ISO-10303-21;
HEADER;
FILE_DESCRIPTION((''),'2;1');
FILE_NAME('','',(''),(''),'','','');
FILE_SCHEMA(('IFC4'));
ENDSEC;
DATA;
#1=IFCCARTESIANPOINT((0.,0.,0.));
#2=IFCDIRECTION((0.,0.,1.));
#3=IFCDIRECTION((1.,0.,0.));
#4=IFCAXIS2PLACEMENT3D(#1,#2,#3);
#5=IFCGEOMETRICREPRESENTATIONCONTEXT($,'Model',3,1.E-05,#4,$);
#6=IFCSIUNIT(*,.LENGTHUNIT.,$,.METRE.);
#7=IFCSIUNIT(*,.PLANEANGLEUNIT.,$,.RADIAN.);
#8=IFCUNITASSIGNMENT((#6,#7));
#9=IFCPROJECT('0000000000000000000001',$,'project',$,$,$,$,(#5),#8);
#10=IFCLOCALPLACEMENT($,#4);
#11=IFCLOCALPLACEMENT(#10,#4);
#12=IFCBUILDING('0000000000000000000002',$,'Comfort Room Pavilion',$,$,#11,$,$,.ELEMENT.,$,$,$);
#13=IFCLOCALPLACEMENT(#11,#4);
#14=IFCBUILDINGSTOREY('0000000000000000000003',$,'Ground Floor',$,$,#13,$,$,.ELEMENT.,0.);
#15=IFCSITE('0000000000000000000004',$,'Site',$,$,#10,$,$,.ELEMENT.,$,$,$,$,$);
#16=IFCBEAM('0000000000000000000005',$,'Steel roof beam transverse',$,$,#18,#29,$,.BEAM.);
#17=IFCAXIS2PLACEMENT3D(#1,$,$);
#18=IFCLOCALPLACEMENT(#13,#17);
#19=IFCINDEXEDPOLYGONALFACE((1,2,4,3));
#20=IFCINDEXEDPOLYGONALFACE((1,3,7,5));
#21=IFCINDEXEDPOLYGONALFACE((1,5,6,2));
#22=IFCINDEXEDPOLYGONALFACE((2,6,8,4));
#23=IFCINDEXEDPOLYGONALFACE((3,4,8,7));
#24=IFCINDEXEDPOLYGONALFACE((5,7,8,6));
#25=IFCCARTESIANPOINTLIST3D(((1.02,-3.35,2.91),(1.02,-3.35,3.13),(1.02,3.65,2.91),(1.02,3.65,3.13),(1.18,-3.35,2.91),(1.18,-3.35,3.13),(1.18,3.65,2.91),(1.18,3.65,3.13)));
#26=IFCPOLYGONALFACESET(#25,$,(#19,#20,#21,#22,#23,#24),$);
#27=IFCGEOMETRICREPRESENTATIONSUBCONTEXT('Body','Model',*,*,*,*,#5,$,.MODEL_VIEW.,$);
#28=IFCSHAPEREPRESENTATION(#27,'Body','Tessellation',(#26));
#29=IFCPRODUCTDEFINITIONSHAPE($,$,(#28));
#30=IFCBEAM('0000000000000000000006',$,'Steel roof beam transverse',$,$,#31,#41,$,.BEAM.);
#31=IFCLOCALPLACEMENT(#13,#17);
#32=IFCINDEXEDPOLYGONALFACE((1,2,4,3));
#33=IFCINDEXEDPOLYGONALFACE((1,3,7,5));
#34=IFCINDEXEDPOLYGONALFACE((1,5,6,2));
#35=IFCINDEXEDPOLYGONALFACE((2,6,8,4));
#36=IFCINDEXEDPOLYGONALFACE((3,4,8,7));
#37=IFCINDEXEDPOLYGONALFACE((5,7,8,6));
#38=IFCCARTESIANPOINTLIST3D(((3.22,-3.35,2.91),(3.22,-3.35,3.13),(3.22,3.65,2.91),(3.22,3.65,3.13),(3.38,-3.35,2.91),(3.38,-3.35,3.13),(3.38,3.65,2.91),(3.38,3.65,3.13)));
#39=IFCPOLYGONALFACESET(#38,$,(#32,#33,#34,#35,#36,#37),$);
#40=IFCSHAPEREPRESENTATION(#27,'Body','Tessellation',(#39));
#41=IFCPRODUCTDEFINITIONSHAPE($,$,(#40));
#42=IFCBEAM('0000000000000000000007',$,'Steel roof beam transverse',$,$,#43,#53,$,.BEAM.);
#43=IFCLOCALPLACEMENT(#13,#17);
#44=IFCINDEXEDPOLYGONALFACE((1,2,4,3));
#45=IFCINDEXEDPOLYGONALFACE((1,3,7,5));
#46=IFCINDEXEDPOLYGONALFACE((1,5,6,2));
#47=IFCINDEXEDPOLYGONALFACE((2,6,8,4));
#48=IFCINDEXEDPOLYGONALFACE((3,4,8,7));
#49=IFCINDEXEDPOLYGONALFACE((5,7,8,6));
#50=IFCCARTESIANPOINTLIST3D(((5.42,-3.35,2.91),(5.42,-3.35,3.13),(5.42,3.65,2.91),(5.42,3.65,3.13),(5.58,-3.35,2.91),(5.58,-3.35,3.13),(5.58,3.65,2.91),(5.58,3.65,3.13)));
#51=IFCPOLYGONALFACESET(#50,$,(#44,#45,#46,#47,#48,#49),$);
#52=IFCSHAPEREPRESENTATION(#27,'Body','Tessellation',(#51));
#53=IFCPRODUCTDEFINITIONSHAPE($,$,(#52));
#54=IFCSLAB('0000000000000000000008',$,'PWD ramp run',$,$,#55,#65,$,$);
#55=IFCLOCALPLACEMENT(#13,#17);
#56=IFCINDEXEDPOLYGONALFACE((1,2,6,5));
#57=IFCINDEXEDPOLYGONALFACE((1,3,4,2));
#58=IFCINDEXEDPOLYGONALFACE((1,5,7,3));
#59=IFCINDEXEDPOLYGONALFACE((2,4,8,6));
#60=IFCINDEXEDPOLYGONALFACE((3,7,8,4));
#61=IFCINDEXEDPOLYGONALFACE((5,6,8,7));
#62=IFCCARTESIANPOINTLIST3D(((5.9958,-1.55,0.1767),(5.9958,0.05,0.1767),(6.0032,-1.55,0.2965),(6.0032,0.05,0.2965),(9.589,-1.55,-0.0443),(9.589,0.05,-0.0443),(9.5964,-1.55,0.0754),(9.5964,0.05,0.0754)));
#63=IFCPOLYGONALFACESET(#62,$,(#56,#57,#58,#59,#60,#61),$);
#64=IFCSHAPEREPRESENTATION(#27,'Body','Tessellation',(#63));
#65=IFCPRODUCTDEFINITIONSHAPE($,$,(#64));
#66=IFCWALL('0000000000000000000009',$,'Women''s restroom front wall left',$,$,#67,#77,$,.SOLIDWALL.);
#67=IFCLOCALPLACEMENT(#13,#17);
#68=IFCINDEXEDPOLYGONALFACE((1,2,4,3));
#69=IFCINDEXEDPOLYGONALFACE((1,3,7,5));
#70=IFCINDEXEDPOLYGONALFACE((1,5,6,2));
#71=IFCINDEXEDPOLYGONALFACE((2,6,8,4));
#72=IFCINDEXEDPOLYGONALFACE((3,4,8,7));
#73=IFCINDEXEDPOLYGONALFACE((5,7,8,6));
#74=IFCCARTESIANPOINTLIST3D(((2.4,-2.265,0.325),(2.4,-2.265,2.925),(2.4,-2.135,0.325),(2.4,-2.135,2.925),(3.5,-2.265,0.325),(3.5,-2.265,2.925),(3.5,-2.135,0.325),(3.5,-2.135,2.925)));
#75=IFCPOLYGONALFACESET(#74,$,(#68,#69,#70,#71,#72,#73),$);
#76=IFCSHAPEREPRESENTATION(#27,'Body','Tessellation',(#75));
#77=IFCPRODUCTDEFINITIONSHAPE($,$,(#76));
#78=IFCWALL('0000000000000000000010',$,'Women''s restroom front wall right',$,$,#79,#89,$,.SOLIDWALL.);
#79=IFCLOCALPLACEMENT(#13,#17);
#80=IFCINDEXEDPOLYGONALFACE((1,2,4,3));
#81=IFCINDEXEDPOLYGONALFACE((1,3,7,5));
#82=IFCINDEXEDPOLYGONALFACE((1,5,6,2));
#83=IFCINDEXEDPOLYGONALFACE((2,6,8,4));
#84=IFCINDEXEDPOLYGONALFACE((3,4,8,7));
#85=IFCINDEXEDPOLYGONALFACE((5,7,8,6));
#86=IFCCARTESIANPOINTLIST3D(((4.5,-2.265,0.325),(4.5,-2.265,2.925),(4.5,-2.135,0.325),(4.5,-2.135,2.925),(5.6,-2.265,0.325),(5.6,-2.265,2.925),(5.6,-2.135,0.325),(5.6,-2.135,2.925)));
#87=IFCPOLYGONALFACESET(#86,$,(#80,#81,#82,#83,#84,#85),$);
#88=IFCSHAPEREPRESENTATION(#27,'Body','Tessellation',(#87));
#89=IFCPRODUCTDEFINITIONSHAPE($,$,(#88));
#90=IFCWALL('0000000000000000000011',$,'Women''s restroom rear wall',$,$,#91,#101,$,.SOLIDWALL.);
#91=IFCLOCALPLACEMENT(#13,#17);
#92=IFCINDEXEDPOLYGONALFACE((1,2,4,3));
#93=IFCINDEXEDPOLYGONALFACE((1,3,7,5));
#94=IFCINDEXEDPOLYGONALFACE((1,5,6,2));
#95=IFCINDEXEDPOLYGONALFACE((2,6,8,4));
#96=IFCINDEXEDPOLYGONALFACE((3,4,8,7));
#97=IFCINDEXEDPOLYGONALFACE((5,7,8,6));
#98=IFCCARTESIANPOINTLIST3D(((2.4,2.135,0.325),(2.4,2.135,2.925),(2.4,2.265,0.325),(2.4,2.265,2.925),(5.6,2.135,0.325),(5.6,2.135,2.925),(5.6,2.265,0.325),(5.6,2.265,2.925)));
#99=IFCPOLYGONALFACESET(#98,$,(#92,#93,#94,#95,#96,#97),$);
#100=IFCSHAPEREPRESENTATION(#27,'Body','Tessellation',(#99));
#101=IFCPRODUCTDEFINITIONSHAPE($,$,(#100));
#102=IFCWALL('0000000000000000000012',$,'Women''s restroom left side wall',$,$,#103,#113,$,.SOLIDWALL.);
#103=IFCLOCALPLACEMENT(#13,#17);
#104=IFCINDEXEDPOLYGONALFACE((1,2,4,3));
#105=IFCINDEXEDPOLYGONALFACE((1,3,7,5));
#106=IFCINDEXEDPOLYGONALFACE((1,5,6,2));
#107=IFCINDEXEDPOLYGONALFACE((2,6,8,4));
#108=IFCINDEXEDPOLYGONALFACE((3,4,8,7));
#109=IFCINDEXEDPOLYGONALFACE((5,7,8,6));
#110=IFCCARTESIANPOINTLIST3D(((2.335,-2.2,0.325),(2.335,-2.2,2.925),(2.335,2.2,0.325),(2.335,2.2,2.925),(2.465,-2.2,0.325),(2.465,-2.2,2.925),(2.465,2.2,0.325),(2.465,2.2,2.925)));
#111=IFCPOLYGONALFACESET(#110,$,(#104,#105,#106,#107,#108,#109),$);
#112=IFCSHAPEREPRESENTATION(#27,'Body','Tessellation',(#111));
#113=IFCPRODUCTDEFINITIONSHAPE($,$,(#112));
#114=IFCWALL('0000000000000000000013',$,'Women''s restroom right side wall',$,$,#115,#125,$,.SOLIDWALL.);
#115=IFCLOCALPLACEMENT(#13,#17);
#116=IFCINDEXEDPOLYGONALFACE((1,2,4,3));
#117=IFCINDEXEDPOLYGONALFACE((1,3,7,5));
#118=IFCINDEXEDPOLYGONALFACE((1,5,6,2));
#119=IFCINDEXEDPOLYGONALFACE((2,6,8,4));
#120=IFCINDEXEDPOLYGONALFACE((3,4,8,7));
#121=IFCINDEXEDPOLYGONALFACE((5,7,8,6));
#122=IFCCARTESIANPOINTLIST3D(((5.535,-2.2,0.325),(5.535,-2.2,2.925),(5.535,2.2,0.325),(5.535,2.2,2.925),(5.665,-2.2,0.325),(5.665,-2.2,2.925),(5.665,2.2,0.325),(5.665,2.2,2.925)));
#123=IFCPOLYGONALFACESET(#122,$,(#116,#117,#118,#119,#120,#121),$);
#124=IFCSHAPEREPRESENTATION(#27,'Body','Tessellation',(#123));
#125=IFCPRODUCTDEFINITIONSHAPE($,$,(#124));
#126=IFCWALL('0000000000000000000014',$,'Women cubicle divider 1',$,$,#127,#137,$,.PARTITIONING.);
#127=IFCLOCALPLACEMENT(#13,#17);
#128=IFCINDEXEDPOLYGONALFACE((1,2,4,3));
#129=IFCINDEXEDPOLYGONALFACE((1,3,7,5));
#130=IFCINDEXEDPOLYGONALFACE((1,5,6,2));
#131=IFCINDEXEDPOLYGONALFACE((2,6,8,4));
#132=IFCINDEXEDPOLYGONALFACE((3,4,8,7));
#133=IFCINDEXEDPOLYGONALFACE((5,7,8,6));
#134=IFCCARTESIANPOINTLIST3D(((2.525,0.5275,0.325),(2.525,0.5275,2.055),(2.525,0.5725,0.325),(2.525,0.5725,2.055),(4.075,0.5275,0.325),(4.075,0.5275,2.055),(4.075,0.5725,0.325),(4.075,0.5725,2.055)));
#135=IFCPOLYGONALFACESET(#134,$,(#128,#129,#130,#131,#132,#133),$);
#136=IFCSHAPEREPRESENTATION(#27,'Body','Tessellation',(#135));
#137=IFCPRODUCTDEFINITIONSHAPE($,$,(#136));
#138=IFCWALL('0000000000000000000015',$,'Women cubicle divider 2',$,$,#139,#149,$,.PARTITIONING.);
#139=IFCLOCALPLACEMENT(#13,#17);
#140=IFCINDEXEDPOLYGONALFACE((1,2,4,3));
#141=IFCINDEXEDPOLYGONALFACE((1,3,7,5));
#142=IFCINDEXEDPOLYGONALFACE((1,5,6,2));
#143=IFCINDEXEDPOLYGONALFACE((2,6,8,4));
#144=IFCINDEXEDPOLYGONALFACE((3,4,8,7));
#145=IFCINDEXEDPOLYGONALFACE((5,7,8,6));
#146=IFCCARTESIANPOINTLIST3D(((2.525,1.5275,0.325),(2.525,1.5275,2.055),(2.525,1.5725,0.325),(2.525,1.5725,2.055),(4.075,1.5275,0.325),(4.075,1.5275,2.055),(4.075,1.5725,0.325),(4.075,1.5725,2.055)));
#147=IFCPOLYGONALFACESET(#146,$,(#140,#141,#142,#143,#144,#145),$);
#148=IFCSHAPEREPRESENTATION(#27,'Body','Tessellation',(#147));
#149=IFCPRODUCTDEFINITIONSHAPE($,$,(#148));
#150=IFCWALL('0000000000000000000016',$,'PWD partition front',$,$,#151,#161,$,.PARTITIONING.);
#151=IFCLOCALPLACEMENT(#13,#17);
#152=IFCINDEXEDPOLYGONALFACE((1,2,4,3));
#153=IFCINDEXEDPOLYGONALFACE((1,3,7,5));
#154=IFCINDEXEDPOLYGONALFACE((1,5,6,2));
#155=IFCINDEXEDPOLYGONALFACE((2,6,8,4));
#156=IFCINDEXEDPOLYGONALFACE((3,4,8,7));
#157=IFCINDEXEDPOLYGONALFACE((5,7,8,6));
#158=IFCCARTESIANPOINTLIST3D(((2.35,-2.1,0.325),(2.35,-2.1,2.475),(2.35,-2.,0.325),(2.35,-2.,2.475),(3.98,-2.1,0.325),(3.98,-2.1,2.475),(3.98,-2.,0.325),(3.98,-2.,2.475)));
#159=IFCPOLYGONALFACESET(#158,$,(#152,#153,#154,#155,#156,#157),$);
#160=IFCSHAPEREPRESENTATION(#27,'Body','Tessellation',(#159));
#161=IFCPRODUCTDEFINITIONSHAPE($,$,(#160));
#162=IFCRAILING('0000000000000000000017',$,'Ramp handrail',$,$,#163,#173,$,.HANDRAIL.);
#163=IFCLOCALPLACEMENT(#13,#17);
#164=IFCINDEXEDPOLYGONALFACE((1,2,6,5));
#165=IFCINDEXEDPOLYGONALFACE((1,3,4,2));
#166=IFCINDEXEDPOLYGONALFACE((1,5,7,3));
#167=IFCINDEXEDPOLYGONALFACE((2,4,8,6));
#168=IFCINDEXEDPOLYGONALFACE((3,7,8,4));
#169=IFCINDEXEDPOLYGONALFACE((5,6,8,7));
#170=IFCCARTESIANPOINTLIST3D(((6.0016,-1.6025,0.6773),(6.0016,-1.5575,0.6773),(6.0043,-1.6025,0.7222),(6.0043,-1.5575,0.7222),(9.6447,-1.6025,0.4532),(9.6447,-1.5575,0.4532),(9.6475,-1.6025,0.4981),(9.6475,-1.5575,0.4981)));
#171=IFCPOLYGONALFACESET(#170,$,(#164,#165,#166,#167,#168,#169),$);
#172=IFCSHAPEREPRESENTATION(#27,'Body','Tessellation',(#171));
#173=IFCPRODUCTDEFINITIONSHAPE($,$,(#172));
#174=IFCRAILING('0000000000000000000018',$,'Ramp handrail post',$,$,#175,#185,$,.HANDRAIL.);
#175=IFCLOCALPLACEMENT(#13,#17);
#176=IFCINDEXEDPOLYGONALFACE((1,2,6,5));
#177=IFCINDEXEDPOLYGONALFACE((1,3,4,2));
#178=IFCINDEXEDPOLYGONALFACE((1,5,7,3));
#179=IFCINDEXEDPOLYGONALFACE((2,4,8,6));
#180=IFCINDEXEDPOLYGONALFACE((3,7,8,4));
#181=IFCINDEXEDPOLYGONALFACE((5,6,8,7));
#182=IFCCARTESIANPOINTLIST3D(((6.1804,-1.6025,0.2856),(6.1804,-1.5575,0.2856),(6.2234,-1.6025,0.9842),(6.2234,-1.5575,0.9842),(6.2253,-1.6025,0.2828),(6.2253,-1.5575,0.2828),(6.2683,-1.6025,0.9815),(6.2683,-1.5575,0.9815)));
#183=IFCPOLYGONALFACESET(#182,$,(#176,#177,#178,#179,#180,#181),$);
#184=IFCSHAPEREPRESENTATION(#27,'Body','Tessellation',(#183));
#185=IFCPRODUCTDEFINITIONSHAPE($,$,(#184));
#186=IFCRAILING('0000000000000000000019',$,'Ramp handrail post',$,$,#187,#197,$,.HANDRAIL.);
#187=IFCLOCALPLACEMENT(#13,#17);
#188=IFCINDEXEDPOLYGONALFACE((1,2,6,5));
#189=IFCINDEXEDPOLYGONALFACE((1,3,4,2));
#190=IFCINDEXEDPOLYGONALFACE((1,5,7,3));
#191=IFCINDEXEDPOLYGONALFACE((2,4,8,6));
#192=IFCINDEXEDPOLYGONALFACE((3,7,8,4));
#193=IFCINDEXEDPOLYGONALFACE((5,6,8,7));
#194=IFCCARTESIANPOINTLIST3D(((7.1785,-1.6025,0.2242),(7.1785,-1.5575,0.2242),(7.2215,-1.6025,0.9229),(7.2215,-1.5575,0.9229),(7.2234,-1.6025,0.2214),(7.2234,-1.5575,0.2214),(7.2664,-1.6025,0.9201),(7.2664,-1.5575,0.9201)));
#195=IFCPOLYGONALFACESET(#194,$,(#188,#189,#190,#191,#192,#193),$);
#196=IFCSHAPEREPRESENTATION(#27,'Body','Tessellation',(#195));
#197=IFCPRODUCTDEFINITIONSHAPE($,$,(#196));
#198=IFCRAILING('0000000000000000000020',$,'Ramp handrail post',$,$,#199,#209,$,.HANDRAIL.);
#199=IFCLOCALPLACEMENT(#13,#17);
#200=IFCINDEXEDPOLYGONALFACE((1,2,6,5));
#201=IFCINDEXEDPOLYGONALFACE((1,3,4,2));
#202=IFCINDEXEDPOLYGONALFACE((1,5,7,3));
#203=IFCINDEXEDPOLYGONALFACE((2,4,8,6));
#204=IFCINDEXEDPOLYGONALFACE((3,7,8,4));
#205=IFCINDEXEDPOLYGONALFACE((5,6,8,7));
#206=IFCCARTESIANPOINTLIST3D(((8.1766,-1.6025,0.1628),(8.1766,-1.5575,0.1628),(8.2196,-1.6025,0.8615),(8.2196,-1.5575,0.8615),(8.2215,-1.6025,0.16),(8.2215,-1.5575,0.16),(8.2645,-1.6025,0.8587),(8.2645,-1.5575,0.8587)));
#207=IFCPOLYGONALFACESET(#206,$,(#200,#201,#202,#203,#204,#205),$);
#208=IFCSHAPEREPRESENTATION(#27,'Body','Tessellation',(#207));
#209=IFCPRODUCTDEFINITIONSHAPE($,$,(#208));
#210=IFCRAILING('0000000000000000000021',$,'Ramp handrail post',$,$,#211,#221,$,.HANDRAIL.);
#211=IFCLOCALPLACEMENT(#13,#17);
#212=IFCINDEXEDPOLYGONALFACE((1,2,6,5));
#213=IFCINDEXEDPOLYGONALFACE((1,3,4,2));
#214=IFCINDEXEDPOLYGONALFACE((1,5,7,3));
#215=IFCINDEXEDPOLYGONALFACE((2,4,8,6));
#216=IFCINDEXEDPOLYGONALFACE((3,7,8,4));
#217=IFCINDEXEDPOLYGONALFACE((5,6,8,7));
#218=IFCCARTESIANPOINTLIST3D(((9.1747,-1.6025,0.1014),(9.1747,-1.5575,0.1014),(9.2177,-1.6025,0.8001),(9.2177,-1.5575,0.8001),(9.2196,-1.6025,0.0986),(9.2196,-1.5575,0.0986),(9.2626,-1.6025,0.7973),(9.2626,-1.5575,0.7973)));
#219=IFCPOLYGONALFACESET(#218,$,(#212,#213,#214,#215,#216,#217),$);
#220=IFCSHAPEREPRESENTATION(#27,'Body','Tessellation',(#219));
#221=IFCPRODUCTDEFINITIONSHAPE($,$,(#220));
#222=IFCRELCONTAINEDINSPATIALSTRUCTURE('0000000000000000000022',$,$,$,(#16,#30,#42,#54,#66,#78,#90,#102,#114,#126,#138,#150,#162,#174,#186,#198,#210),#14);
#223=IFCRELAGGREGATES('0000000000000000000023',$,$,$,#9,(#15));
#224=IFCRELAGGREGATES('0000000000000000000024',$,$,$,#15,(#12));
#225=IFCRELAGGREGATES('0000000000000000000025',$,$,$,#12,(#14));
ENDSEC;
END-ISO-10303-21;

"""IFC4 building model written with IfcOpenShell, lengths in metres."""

from ifc_helpers import new_model, si_unit, frame, origin_with_axes, origin_2d, place, context, subcontext, project, spatial, rectangle, extrude, element, save


model = new_model("IFC4")

# Units and contexts
model_context = context("Model", 3, precision=1e-05, world=origin_with_axes())
body_context = subcontext(model_context, "Body", "Model", "MODEL_VIEW")
ifc_project = project(units=[si_unit("LENGTHUNIT", "METRE"), si_unit("PLANEANGLEUNIT", "RADIAN")], contexts=[model_context])

# Site, building, storey
site_placement = place(None, origin_with_axes())
site = spatial("IfcSite", under=ifc_project, at=site_placement, Name="Site", CompositionType="ELEMENT")
building_placement = place(site_placement, origin_with_axes())
building = spatial("IfcBuilding", under=site, at=building_placement, Name="Comfort Room Pavilion", CompositionType="ELEMENT")
storey_placement = place(building_placement, origin_with_axes())
storey = spatial("IfcBuildingStorey", under=building, at=storey_placement, Name="Ground Floor", CompositionType="ELEMENT", Elevation=0.0)

# Beams
for number, where, z_axis, x_axis, name in (
    (1, (1.1, 0.15, 2.91), (0.0, 0.0, 1.0), (1.0, 0.0, 0.0), "Steel roof beam transverse"),
    (2, (3.3, 0.15, 2.91), (0.0, 0.0, 1.0), (1.0, 0.0, 0.0), "Steel roof beam transverse"),
    (3, (5.5, 0.15, 2.91), (0.0, 0.0, 1.0), (1.0, 0.0, 0.0), "Steel roof beam transverse"),
):
    element("IfcBeam", number, at=place(storey_placement, frame(where, z_axis=z_axis, x_axis=x_axis)), inside=storey, Name=name, PredefinedType="BEAM", context=body_context, shape_type="SweptSolid", body=[
        extrude(rectangle(XDim=0.16, YDim=7.0, at=origin_2d()), origin_with_axes(), (0.0, 0.0, 1.0), 0.22),
    ])

# Slab
slab_placement = place(storey_placement, frame((7.7924, -0.75, 0.0662), z_axis=(0.061397, 0.0, 0.998113), x_axis=(0.998113, 0.0, -0.061397)))
element("IfcSlab", 4, at=slab_placement, inside=storey, Name="PWD ramp run", context=body_context, shape_type="SweptSolid", body=[
    extrude(rectangle(XDim=3.6, YDim=1.6, at=origin_2d()), origin_with_axes(), (0.0, 0.0, 1.0), 0.12),
])

# Walls
for number, where, z_axis, x_axis, name in (
    (5, (2.95, -2.2, 0.325), (0.0, 0.0, 1.0), (1.0, 0.0, 0.0), "Women's restroom front wall left"),
    (6, (5.05, -2.2, 0.325), (0.0, 0.0, 1.0), (1.0, 0.0, 0.0), "Women's restroom front wall right"),
):
    element("IfcWall", number, at=place(storey_placement, frame(where, z_axis=z_axis, x_axis=x_axis)), inside=storey, Name=name, PredefinedType="SOLIDWALL", context=body_context, shape_type="SweptSolid", body=[
        extrude(rectangle(XDim=1.1, YDim=0.13, at=origin_2d()), origin_with_axes(), (0.0, 0.0, 1.0), 2.6),
    ])
wall_1_placement = place(storey_placement, frame((4.0, 2.2, 0.325), z_axis=(0.0, 0.0, 1.0), x_axis=(1.0, 0.0, 0.0)))
element("IfcWall", 7, at=wall_1_placement, inside=storey, Name="Women's restroom rear wall", PredefinedType="SOLIDWALL", context=body_context, shape_type="SweptSolid", body=[
    extrude(rectangle(XDim=3.2, YDim=0.13, at=origin_2d()), origin_with_axes(), (0.0, 0.0, 1.0), 2.6),
])
for number, where, z_axis, x_axis, name in (
    (8, (2.4, 0.0, 0.325), (0.0, 0.0, 1.0), (1.0, 0.0, 0.0), "Women's restroom left side wall"),
    (9, (5.6, 0.0, 0.325), (0.0, 0.0, 1.0), (1.0, 0.0, 0.0), "Women's restroom right side wall"),
):
    element("IfcWall", number, at=place(storey_placement, frame(where, z_axis=z_axis, x_axis=x_axis)), inside=storey, Name=name, PredefinedType="SOLIDWALL", context=body_context, shape_type="SweptSolid", body=[
        extrude(rectangle(XDim=0.13, YDim=4.4, at=origin_2d()), origin_with_axes(), (0.0, 0.0, 1.0), 2.6),
    ])
for number, where, z_axis, x_axis, name in (
    (10, (3.3, 0.55, 0.325), (0.0, 0.0, 1.0), (1.0, 0.0, 0.0), "Women cubicle divider 1"),
    (11, (3.3, 1.55, 0.325), (0.0, 0.0, 1.0), (1.0, 0.0, 0.0), "Women cubicle divider 2"),
):
    element("IfcWall", number, at=place(storey_placement, frame(where, z_axis=z_axis, x_axis=x_axis)), inside=storey, Name=name, PredefinedType="PARTITIONING", context=body_context, shape_type="SweptSolid", body=[
        extrude(rectangle(XDim=1.55, YDim=0.045, at=origin_2d()), origin_with_axes(), (0.0, 0.0, 1.0), 1.73),
    ])
wall_2_placement = place(storey_placement, frame((3.165, -2.05, 0.325), z_axis=(0.0, 0.0, 1.0), x_axis=(1.0, 0.0, 0.0)))
element("IfcWall", 12, at=wall_2_placement, inside=storey, Name="PWD partition front", PredefinedType="PARTITIONING", context=body_context, shape_type="SweptSolid", body=[
    extrude(rectangle(XDim=1.63, YDim=0.1, at=origin_2d()), origin_with_axes(), (0.0, 0.0, 1.0), 2.15),
])

# Railings
railing_1_placement = place(storey_placement, frame((7.8231, -1.58, 0.5652), z_axis=(0.061397, 0.0, 0.998113), x_axis=(0.998113, 0.0, -0.061397)))
element("IfcRailing", 13, at=railing_1_placement, inside=storey, Name="Ramp handrail", PredefinedType="HANDRAIL", context=body_context, shape_type="SweptSolid", body=[
    extrude(rectangle(XDim=3.65, YDim=0.045, at=origin_2d()), origin_with_axes(), (0.0, 0.0, 1.0), 0.045),
])
for number, where, z_axis, x_axis, name in (
    (14, (6.2028, -1.58, 0.2842), (0.061397, 0.0, 0.998113), (0.998113, 0.0, -0.061397), "Ramp handrail post"),
    (15, (7.2009, -1.58, 0.2228), (0.061397, 0.0, 0.998113), (0.998113, 0.0, -0.061397), "Ramp handrail post"),
    (16, (8.1991, -1.58, 0.1614), (0.061397, 0.0, 0.998113), (0.998113, 0.0, -0.061397), "Ramp handrail post"),
    (17, (9.1972, -1.58, 0.1), (0.061397, 0.0, 0.998113), (0.998113, 0.0, -0.061397), "Ramp handrail post"),
):
    element("IfcRailing", number, at=place(storey_placement, frame(where, z_axis=z_axis, x_axis=x_axis)), inside=storey, Name=name, PredefinedType="HANDRAIL", context=body_context, shape_type="SweptSolid", body=[
        extrude(rectangle(XDim=0.045, YDim=0.045, at=origin_2d()), origin_with_axes(), (0.0, 0.0, 1.0), 0.7),
    ])

save(model, "model.ifc")
